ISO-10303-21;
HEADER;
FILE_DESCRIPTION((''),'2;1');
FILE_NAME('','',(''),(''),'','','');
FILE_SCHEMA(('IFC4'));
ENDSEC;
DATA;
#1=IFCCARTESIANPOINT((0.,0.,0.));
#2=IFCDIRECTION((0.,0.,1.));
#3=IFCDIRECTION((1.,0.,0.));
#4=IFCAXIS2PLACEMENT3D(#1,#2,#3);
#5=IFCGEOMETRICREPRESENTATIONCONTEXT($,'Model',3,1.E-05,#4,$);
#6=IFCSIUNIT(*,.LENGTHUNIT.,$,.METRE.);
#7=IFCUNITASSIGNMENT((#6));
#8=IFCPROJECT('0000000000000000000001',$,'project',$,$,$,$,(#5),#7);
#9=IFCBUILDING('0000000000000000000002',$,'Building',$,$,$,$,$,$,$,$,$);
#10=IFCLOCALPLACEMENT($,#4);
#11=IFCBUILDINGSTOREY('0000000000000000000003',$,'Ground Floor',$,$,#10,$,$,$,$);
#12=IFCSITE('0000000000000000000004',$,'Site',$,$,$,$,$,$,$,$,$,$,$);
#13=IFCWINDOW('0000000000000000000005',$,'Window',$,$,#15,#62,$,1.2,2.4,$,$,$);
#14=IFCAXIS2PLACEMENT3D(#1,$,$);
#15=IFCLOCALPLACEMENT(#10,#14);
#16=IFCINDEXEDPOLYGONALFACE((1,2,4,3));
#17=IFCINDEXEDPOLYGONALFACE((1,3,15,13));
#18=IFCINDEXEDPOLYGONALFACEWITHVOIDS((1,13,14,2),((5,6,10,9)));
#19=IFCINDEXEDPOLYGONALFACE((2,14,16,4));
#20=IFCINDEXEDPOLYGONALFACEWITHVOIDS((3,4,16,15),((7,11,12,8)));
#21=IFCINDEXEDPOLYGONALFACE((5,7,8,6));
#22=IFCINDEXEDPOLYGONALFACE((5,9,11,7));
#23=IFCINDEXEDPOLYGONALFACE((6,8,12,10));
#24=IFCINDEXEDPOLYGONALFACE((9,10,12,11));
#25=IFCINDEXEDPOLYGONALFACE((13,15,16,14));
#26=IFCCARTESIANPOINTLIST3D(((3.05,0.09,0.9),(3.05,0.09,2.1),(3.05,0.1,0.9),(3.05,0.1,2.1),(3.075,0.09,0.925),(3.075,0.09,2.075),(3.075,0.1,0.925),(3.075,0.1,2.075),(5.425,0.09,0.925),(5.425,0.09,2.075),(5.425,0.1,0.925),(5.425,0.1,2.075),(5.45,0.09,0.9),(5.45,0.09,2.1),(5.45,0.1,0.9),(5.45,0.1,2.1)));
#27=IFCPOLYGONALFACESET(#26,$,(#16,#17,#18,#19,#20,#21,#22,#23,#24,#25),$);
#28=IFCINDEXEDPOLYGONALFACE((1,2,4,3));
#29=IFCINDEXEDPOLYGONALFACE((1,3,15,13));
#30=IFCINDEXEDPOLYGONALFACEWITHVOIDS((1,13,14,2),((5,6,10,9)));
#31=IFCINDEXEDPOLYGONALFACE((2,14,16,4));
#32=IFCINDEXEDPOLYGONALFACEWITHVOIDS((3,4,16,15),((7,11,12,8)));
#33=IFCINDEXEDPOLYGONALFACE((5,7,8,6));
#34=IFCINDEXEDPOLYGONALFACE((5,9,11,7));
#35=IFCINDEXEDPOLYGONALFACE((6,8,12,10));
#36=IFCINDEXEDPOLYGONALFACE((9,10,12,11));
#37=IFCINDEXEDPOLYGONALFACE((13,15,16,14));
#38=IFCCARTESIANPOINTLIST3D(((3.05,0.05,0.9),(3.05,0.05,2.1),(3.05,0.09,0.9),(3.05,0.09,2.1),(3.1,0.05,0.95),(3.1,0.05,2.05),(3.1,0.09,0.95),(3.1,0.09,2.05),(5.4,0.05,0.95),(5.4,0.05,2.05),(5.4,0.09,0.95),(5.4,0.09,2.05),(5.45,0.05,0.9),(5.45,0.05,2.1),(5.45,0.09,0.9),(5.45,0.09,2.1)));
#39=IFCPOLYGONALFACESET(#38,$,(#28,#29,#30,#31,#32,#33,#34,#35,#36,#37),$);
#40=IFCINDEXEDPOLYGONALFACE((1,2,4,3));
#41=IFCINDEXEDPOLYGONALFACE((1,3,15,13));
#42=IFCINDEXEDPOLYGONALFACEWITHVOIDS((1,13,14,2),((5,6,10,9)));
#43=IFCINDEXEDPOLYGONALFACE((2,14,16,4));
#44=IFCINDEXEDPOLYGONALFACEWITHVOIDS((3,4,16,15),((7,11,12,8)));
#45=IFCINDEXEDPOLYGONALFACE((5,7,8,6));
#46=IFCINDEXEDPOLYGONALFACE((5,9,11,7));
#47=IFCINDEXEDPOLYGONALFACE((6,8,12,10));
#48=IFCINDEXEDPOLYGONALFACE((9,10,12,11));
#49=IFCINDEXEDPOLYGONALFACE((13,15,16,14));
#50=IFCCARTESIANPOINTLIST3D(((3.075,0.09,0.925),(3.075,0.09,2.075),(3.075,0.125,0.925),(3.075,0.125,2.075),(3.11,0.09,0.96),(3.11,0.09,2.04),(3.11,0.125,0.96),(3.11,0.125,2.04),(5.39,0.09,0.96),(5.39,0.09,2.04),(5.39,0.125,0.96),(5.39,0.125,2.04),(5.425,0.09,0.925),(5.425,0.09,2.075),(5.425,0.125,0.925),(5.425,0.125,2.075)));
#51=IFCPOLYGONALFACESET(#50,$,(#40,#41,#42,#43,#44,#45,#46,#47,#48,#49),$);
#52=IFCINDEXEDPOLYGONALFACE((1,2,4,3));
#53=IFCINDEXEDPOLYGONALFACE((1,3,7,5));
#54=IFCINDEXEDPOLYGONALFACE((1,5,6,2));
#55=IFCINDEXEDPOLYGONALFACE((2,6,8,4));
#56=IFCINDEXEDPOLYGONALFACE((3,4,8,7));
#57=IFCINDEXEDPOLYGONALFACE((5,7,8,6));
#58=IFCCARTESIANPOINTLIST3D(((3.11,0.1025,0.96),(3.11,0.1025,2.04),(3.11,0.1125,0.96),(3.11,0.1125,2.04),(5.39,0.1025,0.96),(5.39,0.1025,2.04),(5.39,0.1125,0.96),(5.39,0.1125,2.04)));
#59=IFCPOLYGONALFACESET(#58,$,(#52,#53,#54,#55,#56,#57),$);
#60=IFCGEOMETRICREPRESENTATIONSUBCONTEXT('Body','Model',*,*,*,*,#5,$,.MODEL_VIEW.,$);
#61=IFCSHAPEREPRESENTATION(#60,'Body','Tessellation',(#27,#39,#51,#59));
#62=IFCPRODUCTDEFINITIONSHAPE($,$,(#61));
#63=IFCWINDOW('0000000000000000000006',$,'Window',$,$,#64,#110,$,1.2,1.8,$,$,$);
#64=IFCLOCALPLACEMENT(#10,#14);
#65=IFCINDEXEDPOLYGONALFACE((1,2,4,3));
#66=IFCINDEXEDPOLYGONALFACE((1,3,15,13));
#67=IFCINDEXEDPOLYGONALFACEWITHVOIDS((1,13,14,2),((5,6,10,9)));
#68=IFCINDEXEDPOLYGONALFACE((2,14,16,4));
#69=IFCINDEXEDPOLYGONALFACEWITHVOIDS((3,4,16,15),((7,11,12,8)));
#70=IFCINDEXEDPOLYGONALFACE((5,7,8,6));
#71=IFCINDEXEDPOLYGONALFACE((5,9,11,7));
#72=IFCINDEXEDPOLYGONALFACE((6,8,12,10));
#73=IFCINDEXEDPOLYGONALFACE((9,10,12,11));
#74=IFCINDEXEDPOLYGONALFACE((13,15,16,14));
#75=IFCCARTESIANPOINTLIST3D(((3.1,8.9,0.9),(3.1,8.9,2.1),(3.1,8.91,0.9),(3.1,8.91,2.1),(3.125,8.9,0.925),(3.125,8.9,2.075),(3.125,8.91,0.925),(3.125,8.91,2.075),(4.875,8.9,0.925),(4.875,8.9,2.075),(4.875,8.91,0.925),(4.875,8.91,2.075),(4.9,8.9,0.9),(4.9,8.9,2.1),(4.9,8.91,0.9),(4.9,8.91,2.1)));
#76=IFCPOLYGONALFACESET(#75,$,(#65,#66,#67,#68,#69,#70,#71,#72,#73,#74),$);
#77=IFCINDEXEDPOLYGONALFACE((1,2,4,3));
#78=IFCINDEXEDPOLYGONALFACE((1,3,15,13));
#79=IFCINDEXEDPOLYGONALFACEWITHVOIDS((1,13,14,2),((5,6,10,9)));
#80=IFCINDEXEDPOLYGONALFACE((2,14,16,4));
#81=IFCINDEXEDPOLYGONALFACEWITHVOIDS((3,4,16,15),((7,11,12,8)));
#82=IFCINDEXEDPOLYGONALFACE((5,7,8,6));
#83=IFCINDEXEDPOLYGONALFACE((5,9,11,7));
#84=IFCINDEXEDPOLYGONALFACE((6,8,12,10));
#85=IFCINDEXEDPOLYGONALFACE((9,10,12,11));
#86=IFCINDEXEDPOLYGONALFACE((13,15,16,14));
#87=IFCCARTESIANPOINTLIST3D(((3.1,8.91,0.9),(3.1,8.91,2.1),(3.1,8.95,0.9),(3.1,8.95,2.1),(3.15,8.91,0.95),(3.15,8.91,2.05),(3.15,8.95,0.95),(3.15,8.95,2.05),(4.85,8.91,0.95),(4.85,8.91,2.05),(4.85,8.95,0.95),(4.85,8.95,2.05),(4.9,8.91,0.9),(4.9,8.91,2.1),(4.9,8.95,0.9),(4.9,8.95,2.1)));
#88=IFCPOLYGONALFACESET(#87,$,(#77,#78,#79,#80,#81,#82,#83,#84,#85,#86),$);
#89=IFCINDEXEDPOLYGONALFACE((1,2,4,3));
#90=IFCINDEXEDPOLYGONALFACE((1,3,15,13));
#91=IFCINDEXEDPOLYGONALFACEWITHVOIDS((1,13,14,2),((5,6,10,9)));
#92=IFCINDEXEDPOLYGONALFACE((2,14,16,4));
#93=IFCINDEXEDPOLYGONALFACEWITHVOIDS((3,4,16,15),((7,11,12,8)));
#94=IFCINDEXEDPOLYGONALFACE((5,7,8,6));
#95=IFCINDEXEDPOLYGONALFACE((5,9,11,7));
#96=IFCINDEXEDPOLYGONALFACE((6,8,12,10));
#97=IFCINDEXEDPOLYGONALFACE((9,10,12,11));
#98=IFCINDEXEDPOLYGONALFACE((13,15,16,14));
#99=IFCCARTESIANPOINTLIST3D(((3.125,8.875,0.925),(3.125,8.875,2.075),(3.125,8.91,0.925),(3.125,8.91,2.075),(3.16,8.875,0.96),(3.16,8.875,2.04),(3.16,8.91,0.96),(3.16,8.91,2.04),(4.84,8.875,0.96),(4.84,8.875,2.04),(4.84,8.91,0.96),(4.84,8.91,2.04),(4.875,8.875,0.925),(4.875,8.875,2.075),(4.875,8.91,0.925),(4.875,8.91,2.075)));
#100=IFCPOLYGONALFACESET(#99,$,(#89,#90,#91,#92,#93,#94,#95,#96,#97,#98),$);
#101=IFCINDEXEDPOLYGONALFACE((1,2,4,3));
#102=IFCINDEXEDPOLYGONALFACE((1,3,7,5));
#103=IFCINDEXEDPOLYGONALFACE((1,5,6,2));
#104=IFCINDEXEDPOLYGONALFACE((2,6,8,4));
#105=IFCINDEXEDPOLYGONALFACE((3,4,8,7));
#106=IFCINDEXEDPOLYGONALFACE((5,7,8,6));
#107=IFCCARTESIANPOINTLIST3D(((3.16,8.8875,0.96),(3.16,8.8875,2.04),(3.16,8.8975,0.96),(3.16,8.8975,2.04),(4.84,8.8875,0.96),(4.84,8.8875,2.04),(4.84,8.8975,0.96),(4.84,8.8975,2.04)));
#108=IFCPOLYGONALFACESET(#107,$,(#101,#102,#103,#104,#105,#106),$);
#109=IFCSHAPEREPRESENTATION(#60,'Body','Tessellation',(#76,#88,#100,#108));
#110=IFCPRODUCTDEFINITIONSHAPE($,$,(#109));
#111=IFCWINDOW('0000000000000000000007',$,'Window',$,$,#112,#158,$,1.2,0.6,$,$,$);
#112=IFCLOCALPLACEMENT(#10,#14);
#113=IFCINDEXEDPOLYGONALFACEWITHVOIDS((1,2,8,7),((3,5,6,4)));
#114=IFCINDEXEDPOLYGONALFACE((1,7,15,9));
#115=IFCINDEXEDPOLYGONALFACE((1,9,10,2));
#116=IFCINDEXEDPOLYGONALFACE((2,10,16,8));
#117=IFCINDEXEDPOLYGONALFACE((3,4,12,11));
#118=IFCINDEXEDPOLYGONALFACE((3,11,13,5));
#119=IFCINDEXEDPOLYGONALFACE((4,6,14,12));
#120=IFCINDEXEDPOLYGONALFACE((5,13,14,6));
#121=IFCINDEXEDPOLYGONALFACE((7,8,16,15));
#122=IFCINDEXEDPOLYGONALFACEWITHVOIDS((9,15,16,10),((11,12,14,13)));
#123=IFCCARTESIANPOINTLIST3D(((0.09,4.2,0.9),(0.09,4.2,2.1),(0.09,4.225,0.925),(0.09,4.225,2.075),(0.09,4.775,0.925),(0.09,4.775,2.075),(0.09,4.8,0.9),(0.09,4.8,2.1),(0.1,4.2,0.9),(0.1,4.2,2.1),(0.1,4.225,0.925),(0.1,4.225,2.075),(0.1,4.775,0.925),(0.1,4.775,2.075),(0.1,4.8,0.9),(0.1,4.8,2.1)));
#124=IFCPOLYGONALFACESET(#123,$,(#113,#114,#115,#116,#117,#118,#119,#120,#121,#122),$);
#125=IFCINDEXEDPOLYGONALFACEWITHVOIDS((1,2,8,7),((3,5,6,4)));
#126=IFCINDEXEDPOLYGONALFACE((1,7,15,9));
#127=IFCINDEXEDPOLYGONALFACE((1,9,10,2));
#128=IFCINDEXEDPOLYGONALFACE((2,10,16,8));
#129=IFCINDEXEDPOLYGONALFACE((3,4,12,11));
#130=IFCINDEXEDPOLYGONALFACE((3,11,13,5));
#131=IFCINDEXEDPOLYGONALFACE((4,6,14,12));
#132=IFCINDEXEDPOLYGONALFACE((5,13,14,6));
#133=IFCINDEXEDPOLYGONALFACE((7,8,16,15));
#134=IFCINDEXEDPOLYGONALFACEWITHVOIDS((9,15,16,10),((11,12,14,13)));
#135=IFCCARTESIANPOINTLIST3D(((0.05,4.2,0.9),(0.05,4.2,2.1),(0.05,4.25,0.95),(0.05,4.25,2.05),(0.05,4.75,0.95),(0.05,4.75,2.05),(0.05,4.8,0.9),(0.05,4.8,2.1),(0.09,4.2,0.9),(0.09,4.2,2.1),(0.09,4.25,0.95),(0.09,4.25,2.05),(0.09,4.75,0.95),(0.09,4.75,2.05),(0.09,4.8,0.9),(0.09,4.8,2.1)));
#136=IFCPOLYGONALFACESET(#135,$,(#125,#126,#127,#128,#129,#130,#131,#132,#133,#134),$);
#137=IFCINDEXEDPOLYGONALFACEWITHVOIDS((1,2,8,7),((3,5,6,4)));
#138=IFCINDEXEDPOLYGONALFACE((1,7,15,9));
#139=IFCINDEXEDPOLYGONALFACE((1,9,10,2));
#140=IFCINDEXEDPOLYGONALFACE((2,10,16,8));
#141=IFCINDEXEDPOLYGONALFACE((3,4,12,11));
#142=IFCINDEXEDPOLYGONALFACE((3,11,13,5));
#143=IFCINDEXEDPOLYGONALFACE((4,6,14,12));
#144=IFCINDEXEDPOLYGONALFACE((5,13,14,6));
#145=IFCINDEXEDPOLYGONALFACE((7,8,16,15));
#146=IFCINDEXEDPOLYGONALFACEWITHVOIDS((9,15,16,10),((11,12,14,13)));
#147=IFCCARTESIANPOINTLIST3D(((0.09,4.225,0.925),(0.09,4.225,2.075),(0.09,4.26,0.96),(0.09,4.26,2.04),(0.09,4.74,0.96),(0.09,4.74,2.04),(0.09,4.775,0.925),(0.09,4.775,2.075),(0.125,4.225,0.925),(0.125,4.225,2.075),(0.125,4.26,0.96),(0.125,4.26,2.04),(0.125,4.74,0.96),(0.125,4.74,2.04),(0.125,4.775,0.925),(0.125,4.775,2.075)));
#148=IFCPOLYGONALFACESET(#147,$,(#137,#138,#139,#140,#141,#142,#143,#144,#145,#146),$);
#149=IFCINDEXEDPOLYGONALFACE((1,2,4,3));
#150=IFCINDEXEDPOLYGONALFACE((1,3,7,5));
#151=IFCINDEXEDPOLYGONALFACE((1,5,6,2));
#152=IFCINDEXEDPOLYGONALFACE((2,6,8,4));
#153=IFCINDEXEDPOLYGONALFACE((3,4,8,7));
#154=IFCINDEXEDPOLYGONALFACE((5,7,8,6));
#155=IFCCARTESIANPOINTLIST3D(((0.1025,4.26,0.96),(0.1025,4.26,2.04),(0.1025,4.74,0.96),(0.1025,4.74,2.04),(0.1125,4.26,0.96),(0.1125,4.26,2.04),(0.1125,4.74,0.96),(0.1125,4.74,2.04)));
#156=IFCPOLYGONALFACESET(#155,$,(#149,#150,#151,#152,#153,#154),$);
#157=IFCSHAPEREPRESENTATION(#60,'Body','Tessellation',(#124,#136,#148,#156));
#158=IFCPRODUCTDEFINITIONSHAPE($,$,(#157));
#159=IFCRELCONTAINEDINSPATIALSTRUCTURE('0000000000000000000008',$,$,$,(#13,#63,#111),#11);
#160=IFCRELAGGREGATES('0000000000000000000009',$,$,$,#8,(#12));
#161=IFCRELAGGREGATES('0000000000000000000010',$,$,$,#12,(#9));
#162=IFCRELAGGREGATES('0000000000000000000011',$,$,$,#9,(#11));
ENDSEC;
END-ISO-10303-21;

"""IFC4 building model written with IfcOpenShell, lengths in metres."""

from ifc_helpers import new_model, si_unit, frame, origin_with_axes, place, context, subcontext, project, spatial, line, indexed_curve, outline, extrude, element, save


model = new_model("IFC4")

# Units and contexts
model_context = context("Model", 3, precision=1e-05, world=origin_with_axes())
body_context = subcontext(model_context, "Body", "Model", "MODEL_VIEW")
ifc_project = project(units=[si_unit("LENGTHUNIT", "METRE")], contexts=[model_context])

# Site, building, storey
site = spatial("IfcSite", under=ifc_project, Name="Site")
building = spatial("IfcBuilding", under=site, Name="Building")
storey_placement = place(None, origin_with_axes())
storey = spatial("IfcBuildingStorey", under=building, at=storey_placement, Name="Ground Floor")

# Windows
window_1_placement = place(storey_placement, frame((3.05, 0.0, 0.9), z_axis=(0.0, 0.0, 1.0), x_axis=(1.0, 0.0, 0.0)))
element("IfcWindow", 1, at=window_1_placement, inside=storey, Name="Window", OverallHeight=1.2, OverallWidth=2.4, context=body_context, shape_type="SweptSolid", body=[
    extrude(outline(indexed_curve([(0.0, 0.0), (2.4, 0.0), (2.4, 1.2), (0.0, 1.2)], segments=[line(1, 2, 3, 4, 1)]), holes=[indexed_curve([(0.025, 0.025), (2.375, 0.025), (2.375, 1.175), (0.025, 1.175)], segments=[line(1, 2, 3, 4, 1)])]), frame((0.0, 0.09, 0.0), z_axis=(0.0, -1.0, 0.0), x_axis=(1.0, 0.0, 0.0)), (0.0, 0.0, -1.0), 0.01),
    extrude(outline(indexed_curve([(0.0, 0.0), (2.4, 0.0), (2.4, 1.2), (0.0, 1.2)], segments=[line(1, 2, 3, 4, 1)]), holes=[indexed_curve([(0.05, 0.05), (2.35, 0.05), (2.35, 1.15), (0.05, 1.15)], segments=[line(1, 2, 3, 4, 1)])]), frame((0.0, 0.05, 0.0), z_axis=(0.0, -1.0, 0.0), x_axis=(1.0, 0.0, 0.0)), (0.0, 0.0, -1.0), 0.04),
    extrude(outline(indexed_curve([(0.0, 0.0), (2.35, 0.0), (2.35, 1.15), (0.0, 1.15)], segments=[line(1, 2, 3, 4, 1)]), holes=[indexed_curve([(0.035, 0.035), (2.315, 0.035), (2.315, 1.115), (0.035, 1.115)], segments=[line(1, 2, 3, 4, 1)])]), frame((0.025, 0.09, 0.025), z_axis=(0.0, -1.0, 0.0), x_axis=(1.0, 0.0, 0.0)), (0.0, 0.0, -1.0), 0.035),
    extrude(outline(indexed_curve([(0.035, 0.035), (2.315, 0.035), (2.315, 1.115), (0.035, 1.115)], segments=[line(1, 2, 3, 4, 1)])), frame((0.025, 0.1025, 0.025), z_axis=(0.0, -1.0, 0.0), x_axis=(1.0, 0.0, 0.0)), (0.0, 0.0, -1.0), 0.01),
])
window_2_placement = place(storey_placement, frame((4.9, 9.0, 0.9), z_axis=(0.0, 0.0, 1.0), x_axis=(-1.0, 0.0, 0.0)))
element("IfcWindow", 2, at=window_2_placement, inside=storey, Name="Window", OverallHeight=1.2, OverallWidth=1.8, context=body_context, shape_type="SweptSolid", body=[
    extrude(outline(indexed_curve([(0.0, 0.0), (1.8, 0.0), (1.8, 1.2), (0.0, 1.2)], segments=[line(1, 2, 3, 4, 1)]), holes=[indexed_curve([(0.025, 0.025), (1.775, 0.025), (1.775, 1.175), (0.025, 1.175)], segments=[line(1, 2, 3, 4, 1)])]), frame((0.0, 0.09, 0.0), z_axis=(0.0, -1.0, 0.0), x_axis=(1.0, 0.0, 0.0)), (0.0, 0.0, -1.0), 0.01),
    extrude(outline(indexed_curve([(0.0, 0.0), (1.8, 0.0), (1.8, 1.2), (0.0, 1.2)], segments=[line(1, 2, 3, 4, 1)]), holes=[indexed_curve([(0.05, 0.05), (1.75, 0.05), (1.75, 1.15), (0.05, 1.15)], segments=[line(1, 2, 3, 4, 1)])]), frame((0.0, 0.05, 0.0), z_axis=(0.0, -1.0, 0.0), x_axis=(1.0, 0.0, 0.0)), (0.0, 0.0, -1.0), 0.04),
    extrude(outline(indexed_curve([(0.0, 0.0), (1.75, 0.0), (1.75, 1.15), (0.0, 1.15)], segments=[line(1, 2, 3, 4, 1)]), holes=[indexed_curve([(0.035, 0.035), (1.715, 0.035), (1.715, 1.115), (0.035, 1.115)], segments=[line(1, 2, 3, 4, 1)])]), frame((0.025, 0.09, 0.025), z_axis=(0.0, -1.0, 0.0), x_axis=(1.0, 0.0, 0.0)), (0.0, 0.0, -1.0), 0.035),
    extrude(outline(indexed_curve([(0.035, 0.035), (1.715, 0.035), (1.715, 1.115), (0.035, 1.115)], segments=[line(1, 2, 3, 4, 1)])), frame((0.025, 0.1025, 0.025), z_axis=(0.0, -1.0, 0.0), x_axis=(1.0, 0.0, 0.0)), (0.0, 0.0, -1.0), 0.01),
])
window_3_placement = place(storey_placement, frame((0.0, 4.8, 0.9), z_axis=(0.0, 0.0, 1.0), x_axis=(0.0, -1.0, 0.0)))
element("IfcWindow", 3, at=window_3_placement, inside=storey, Name="Window", OverallHeight=1.2, OverallWidth=0.6, context=body_context, shape_type="SweptSolid", body=[
    extrude(outline(indexed_curve([(0.0, 0.0), (0.6, 0.0), (0.6, 1.2), (0.0, 1.2)], segments=[line(1, 2, 3, 4, 1)]), holes=[indexed_curve([(0.025, 0.025), (0.575, 0.025), (0.575, 1.175), (0.025, 1.175)], segments=[line(1, 2, 3, 4, 1)])]), frame((0.0, 0.09, 0.0), z_axis=(0.0, -1.0, 0.0), x_axis=(1.0, 0.0, 0.0)), (0.0, 0.0, -1.0), 0.01),
    extrude(outline(indexed_curve([(0.0, 0.0), (0.6, 0.0), (0.6, 1.2), (0.0, 1.2)], segments=[line(1, 2, 3, 4, 1)]), holes=[indexed_curve([(0.05, 0.05), (0.55, 0.05), (0.55, 1.15), (0.05, 1.15)], segments=[line(1, 2, 3, 4, 1)])]), frame((0.0, 0.05, 0.0), z_axis=(0.0, -1.0, 0.0), x_axis=(1.0, 0.0, 0.0)), (0.0, 0.0, -1.0), 0.04),
    extrude(outline(indexed_curve([(0.0, 0.0), (0.55, 0.0), (0.55, 1.15), (0.0, 1.15)], segments=[line(1, 2, 3, 4, 1)]), holes=[indexed_curve([(0.035, 0.035), (0.515, 0.035), (0.515, 1.115), (0.035, 1.115)], segments=[line(1, 2, 3, 4, 1)])]), frame((0.025, 0.09, 0.025), z_axis=(0.0, -1.0, 0.0), x_axis=(1.0, 0.0, 0.0)), (0.0, 0.0, -1.0), 0.035),
    extrude(outline(indexed_curve([(0.035, 0.035), (0.515, 0.035), (0.515, 1.115), (0.035, 1.115)], segments=[line(1, 2, 3, 4, 1)])), frame((0.025, 0.1025, 0.025), z_axis=(0.0, -1.0, 0.0), x_axis=(1.0, 0.0, 0.0)), (0.0, 0.0, -1.0), 0.01),
])

save(model, "model.ifc")
